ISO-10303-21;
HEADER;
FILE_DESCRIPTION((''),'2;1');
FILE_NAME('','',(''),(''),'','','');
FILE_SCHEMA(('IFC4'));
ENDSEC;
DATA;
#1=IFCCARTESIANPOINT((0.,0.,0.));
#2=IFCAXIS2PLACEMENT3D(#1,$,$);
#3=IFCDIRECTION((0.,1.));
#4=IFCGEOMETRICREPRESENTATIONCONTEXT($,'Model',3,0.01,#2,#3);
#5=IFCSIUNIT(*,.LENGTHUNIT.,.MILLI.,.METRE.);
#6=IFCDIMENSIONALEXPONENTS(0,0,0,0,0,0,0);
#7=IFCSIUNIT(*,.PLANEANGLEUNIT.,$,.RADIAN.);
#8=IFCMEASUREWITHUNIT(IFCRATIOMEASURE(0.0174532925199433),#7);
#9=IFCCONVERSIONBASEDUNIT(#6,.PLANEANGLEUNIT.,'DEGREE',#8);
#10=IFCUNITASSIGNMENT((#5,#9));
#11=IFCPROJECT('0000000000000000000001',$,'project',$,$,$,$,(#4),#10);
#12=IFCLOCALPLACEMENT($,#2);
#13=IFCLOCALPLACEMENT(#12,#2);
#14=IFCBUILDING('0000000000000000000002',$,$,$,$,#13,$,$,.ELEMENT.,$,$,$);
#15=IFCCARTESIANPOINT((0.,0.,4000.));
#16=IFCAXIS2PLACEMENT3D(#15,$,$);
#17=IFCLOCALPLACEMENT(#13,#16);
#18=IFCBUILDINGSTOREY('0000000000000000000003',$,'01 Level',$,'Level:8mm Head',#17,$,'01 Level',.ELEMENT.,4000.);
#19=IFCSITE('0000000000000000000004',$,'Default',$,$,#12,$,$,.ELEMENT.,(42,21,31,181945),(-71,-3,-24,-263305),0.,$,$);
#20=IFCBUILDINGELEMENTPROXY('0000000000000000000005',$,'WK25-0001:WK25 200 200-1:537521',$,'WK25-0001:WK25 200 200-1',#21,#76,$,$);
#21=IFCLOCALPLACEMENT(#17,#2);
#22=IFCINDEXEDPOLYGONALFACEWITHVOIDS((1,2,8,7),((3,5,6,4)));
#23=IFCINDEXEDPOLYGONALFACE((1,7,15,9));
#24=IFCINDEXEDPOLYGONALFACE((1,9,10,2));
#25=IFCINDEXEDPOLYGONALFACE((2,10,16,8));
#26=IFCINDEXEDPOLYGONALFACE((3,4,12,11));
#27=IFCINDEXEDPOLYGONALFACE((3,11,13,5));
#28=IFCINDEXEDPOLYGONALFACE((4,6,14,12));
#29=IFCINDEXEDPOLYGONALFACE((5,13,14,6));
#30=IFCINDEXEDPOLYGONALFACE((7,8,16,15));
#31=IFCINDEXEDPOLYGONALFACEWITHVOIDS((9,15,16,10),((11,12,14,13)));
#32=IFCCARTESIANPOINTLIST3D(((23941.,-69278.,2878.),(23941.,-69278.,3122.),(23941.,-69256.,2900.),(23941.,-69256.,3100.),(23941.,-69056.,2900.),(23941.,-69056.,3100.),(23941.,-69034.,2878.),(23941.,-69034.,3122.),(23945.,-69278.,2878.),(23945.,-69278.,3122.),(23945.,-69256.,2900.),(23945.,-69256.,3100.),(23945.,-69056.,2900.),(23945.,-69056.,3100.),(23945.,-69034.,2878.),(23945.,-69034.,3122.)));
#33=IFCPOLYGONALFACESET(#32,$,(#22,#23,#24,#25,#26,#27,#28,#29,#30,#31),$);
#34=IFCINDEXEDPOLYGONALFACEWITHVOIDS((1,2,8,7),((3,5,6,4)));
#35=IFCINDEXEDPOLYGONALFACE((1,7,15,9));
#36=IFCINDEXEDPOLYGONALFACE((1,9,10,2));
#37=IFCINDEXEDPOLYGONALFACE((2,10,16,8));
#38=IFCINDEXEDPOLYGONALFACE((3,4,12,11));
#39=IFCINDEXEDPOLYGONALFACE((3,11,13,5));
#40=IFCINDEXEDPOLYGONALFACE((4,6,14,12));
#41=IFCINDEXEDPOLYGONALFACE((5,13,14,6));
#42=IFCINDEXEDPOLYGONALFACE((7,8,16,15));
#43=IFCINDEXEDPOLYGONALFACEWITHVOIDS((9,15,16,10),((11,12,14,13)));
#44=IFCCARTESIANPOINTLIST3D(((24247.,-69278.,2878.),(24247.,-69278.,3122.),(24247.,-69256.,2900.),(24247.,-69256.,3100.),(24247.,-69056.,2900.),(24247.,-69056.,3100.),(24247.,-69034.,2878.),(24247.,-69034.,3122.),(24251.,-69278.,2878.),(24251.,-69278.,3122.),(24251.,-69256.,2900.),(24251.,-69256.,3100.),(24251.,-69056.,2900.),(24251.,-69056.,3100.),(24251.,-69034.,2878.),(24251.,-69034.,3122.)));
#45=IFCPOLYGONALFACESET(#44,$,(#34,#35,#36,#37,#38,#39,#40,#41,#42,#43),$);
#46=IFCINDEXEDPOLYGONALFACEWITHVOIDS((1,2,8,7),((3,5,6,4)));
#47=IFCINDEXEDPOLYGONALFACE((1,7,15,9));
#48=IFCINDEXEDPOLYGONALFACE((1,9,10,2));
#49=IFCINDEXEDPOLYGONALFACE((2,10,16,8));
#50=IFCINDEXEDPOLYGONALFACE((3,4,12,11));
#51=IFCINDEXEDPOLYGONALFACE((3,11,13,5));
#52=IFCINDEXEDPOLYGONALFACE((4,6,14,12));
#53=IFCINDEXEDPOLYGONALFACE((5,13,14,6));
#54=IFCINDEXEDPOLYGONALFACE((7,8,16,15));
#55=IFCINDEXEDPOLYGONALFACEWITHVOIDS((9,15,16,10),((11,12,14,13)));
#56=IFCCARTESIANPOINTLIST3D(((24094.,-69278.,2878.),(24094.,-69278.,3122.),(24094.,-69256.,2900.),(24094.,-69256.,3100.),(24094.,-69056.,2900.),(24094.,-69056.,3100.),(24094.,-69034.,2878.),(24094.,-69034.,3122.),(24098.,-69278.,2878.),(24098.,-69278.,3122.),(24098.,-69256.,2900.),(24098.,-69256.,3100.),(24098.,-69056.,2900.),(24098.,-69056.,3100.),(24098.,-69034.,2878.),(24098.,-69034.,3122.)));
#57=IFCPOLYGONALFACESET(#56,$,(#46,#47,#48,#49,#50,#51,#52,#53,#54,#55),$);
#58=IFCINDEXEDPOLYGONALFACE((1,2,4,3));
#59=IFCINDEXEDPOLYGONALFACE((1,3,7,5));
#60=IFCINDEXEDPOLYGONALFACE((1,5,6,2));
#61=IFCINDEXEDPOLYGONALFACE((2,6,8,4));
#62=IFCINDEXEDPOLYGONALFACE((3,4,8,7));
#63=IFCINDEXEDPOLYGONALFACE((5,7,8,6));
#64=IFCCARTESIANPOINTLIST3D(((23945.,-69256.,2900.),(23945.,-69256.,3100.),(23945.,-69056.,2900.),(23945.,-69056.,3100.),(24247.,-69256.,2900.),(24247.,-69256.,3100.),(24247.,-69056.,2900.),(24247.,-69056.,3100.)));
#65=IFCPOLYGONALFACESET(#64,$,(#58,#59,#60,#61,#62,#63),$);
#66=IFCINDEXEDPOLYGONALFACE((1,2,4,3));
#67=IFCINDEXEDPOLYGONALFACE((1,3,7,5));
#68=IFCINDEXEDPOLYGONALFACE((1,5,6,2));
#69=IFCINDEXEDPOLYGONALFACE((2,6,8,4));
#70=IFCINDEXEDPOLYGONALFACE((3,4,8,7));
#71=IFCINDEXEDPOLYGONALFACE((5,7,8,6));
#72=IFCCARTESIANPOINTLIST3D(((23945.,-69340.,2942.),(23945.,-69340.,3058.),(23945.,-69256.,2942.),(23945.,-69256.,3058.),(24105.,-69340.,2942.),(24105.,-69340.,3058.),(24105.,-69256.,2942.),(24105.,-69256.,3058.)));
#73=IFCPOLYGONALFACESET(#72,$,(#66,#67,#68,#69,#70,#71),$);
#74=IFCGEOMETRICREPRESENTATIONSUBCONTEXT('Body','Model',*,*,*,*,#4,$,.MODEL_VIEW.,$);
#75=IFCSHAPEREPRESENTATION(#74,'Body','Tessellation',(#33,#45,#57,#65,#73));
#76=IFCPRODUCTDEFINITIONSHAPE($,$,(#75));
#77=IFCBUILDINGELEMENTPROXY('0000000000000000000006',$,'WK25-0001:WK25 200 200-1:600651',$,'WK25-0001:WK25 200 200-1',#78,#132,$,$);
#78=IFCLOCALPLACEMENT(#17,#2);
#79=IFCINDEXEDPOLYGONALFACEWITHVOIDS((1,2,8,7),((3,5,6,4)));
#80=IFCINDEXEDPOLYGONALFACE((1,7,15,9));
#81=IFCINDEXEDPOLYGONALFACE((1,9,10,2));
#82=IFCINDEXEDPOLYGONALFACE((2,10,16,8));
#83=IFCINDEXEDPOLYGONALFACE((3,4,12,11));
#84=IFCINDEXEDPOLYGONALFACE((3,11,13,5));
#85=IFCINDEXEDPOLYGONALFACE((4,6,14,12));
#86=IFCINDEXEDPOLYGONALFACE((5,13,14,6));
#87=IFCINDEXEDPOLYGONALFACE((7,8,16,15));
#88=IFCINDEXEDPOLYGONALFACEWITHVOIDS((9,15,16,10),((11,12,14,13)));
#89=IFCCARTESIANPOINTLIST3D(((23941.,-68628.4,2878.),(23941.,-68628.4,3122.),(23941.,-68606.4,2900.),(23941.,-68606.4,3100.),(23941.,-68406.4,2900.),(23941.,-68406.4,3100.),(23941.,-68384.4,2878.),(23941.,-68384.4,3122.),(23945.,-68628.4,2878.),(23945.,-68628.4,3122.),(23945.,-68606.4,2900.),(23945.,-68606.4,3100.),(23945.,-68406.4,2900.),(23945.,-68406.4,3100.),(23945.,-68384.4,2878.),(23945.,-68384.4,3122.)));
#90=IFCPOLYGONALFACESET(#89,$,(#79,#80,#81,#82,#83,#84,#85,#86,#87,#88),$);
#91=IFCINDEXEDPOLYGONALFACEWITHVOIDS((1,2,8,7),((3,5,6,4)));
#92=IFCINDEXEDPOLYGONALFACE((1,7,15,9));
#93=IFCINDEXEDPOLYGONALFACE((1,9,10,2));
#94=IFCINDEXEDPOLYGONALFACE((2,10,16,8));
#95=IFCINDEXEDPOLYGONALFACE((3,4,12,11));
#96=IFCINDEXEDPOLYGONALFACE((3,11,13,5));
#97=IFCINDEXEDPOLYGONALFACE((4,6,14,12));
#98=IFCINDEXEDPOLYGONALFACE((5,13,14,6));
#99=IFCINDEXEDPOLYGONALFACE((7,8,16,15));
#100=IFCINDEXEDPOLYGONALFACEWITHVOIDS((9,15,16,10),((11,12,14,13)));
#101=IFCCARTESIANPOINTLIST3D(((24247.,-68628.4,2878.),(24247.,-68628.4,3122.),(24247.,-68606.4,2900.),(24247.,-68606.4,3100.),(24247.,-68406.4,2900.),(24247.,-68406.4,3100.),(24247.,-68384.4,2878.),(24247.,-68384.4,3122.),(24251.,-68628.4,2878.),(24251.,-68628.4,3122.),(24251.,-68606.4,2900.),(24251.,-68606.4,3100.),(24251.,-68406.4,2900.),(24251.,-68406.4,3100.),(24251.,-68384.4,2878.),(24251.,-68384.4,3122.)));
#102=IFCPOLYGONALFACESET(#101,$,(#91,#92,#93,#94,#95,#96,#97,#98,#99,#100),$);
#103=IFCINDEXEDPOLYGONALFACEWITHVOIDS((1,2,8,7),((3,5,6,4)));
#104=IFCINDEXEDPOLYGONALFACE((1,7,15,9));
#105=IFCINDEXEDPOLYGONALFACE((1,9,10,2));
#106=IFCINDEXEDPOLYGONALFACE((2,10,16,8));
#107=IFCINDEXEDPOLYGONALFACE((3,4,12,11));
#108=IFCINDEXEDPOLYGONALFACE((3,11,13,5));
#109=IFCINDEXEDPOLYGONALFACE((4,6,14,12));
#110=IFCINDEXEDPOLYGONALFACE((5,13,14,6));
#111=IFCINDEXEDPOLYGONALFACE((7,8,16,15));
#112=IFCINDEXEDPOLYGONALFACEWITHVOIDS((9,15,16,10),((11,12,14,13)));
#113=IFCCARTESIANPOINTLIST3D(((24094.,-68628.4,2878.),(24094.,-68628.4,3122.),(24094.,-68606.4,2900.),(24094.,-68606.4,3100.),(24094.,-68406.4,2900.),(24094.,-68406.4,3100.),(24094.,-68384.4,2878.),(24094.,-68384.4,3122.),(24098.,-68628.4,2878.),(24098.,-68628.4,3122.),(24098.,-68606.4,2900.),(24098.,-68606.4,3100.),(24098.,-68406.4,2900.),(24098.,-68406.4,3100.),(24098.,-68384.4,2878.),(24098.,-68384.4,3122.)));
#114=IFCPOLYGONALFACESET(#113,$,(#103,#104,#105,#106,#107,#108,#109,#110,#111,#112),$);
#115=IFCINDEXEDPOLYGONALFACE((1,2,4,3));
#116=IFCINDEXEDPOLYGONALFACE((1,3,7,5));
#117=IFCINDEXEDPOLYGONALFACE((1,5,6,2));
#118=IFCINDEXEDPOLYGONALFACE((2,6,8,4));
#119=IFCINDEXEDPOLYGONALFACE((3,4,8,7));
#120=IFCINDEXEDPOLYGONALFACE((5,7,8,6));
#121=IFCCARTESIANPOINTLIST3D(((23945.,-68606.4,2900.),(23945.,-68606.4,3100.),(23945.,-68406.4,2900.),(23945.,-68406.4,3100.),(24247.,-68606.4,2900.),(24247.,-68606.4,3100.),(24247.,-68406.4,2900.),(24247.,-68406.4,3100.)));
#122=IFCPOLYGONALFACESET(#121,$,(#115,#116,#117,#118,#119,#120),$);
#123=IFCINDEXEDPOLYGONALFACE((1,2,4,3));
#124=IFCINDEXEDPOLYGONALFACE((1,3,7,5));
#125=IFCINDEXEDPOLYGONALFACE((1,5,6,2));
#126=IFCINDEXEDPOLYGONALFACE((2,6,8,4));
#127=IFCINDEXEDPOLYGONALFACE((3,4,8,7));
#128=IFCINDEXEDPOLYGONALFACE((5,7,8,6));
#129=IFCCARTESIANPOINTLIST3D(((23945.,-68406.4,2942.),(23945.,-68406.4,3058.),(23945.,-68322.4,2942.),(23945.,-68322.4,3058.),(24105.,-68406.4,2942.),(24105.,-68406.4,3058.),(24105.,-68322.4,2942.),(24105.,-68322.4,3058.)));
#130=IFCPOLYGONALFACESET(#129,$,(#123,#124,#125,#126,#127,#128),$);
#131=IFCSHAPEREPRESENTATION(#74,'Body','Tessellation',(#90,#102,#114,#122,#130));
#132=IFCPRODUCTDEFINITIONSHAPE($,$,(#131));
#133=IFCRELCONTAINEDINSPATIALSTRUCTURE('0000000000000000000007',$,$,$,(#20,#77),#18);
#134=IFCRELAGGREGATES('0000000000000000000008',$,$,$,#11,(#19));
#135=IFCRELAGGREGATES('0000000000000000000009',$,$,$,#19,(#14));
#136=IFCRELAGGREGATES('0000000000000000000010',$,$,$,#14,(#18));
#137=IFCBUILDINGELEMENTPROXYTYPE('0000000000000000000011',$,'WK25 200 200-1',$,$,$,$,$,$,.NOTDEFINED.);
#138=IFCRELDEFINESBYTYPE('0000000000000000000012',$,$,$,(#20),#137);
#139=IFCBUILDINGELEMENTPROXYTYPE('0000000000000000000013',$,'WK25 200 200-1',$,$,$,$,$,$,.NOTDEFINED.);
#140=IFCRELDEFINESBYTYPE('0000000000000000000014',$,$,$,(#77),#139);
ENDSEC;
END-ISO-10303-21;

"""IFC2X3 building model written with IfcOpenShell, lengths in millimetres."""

from ifc_helpers import new_model, entity, si_unit, converted_unit, direction, frame, frame_2d, origin, origin_2d_with_axis, place, context, subcontext, project, spatial, polyline, rectangle, outline, extrude, source, transform, mapped, type_object, type_shapes, element, save


model = new_model("IFC2X3")

# Units and contexts
model_context = context("Model", 3, precision=0.01, world=origin(), true_north=direction((0.0, 1.0)))
body_context = subcontext(model_context, "Body", "Model", "MODEL_VIEW")
ifc_project = project(units=[si_unit("LENGTHUNIT", "METRE", prefix="MILLI"), converted_unit("PLANEANGLEUNIT", "DEGREE", entity("IfcRatioMeasure", 0.0174532925199433), si_unit("PLANEANGLEUNIT", "RADIAN"), dimensions=[0, 0, 0, 0, 0, 0, 0])], contexts=[model_context])

# Site, building, storey
site_placement = place(None, origin())
site = spatial("IfcSite", under=ifc_project, at=site_placement, Name="Default", CompositionType="ELEMENT", RefLatitude=(42, 21, 31, 181945), RefLongitude=(-71, -3, -24, -263305), RefElevation=0.0)
building_placement = place(site_placement, origin())
building = spatial("IfcBuilding", under=site, at=building_placement, CompositionType="ELEMENT")
storey_placement = place(building_placement, frame((0.0, 0.0, 4000.0)))
storey = spatial("IfcBuildingStorey", under=building, at=storey_placement, Name="01 Level", ObjectType="Level:8mm Head", LongName="01 Level", CompositionType="ELEMENT", Elevation=4000.0)

# Building element proxies
building_element_proxy_type_1 = type_object("IfcBuildingElementProxyType", Name="WK25 200 200-1", PredefinedType="NOTDEFINED")
shared_shape_1 = source(origin(), body_context, "Body", "SweptSolid", [
    extrude(outline(polyline([(-122.0, -122.0), (122.0, -122.0), (122.0, 122.0), (-122.0, 122.0), (-122.0, -122.0)]), holes=[polyline([(-100.0, -100.0), (-100.0, 100.0), (100.0, 100.0), (100.0, -100.0), (-100.0, -100.0)])]), frame((151.0, 0.0, 0.0), z_axis=(1.0, 0.0, 0.0), x_axis=(0.0, 0.0, -1.0)), (0.0, 0.0, 1.0), 4.0),
    extrude(outline(polyline([(-122.0, -122.0), (122.0, -122.0), (122.0, 122.0), (-122.0, 122.0), (-122.0, -122.0)]), holes=[polyline([(-100.0, -100.0), (-100.0, 100.0), (100.0, 100.0), (100.0, -100.0), (-100.0, -100.0)])]), frame((-155.0, 0.0, 0.0), z_axis=(1.0, 0.0, 0.0), x_axis=(0.0, -1.0, 0.0)), (0.0, 0.0, 1.0), 4.0),
    extrude(outline(polyline([(-122.0, -122.0), (122.0, -122.0), (122.0, 122.0), (-122.0, 122.0), (-122.0, -122.0)]), holes=[polyline([(-100.0, -100.0), (-100.0, 100.0), (100.0, 100.0), (100.0, -100.0), (-100.0, -100.0)])]), frame((-2.0, 0.0, 0.0), z_axis=(1.0, 0.0, 0.0), x_axis=(0.0, -1.0, 0.0)), (0.0, 0.0, 1.0), 4.0),
    extrude(rectangle(XDim=302.0, YDim=200.0, at=origin_2d_with_axis()), frame((0.0, 0.0, -100.0), z_axis=(0.0, 0.0, 1.0), x_axis=(-1.0, 0.0, 0.0)), (0.0, 0.0, 1.0), 200.0),
    extrude(rectangle(XDim=84.0, YDim=160.0, at=frame_2d((0.0, 0.0), x_axis=(1.0, 0.0))), frame((71.0, -142.0, -58.0), z_axis=(0.0, 0.0, 1.0), x_axis=(0.0, -1.0, 0.0)), (0.0, 0.0, 1.0), 116.0),
])
type_shapes(building_element_proxy_type_1, [shared_shape_1])
proxy_1_placement = place(storey_placement, frame((24096.0, -69156.0, 3000.0), z_axis=(0.0, 0.0, -1.0), x_axis=(-1.0, 0.0, 0.0)))
element("IfcBuildingElementProxy", 1, at=proxy_1_placement, inside=storey, type_object=building_element_proxy_type_1, Name="WK25-0001:WK25 200 200-1:537521", ObjectType="WK25-0001:WK25 200 200-1", context=body_context, shape_type="MappedRepresentation", body=[
    mapped(shared_shape_1, transform((0.0, 0.0, 0.0), scale=1.0)),
])
building_element_proxy_type_2 = type_object("IfcBuildingElementProxyType", Name="WK25 200 200-1", PredefinedType="NOTDEFINED")
shared_shape_2 = source(origin(), body_context, "Body", "SweptSolid", [
    extrude(outline(polyline([(-122.0, -122.0), (122.0, -122.0), (122.0, 122.0), (-122.0, 122.0), (-122.0, -122.0)]), holes=[polyline([(-100.0, -100.0), (-100.0, 100.0), (100.0, 100.0), (100.0, -100.0), (-100.0, -100.0)])]), frame((151.0, 0.0, 0.0), z_axis=(1.0, 0.0, 0.0), x_axis=(0.0, -1.0, 0.0)), (0.0, 0.0, 1.0), 4.0),
    extrude(outline(polyline([(-122.0, -122.0), (122.0, -122.0), (122.0, 122.0), (-122.0, 122.0), (-122.0, -122.0)]), holes=[polyline([(-100.0, -100.0), (-100.0, 100.0), (100.0, 100.0), (100.0, -100.0), (-100.0, -100.0)])]), frame((-155.0, 0.0, 0.0), z_axis=(1.0, 0.0, 0.0), x_axis=(0.0, 0.0, -1.0)), (0.0, 0.0, 1.0), 4.0),
    extrude(outline(polyline([(-122.0, -122.0), (122.0, -122.0), (122.0, 122.0), (-122.0, 122.0), (-122.0, -122.0)]), holes=[polyline([(-100.0, -100.0), (-100.0, 100.0), (100.0, 100.0), (100.0, -100.0), (-100.0, -100.0)])]), frame((-2.0, 0.0, 0.0), z_axis=(1.0, 0.0, 0.0), x_axis=(0.0, 0.0, -1.0)), (0.0, 0.0, 1.0), 4.0),
    extrude(rectangle(XDim=200.0, YDim=302.0, at=origin_2d_with_axis()), frame((0.0, 0.0, -100.0), z_axis=(0.0, 0.0, 1.0), x_axis=(0.0, 1.0, 0.0)), (0.0, 0.0, 1.0), 200.0),
    extrude(rectangle(XDim=160.0, YDim=84.0, at=frame_2d((0.0, 0.0), x_axis=(1.0, 0.0))), frame((71.0, 142.0, -58.0)), (0.0, 0.0, 1.0), 116.0),
])
type_shapes(building_element_proxy_type_2, [shared_shape_2])
proxy_2_placement = place(storey_placement, frame((24096.0, -68506.4, 3000.0), z_axis=(0.0, 0.0, -1.0), x_axis=(-1.0, 0.0, 0.0)))
element("IfcBuildingElementProxy", 2, at=proxy_2_placement, inside=storey, type_object=building_element_proxy_type_2, Name="WK25-0001:WK25 200 200-1:600651", ObjectType="WK25-0001:WK25 200 200-1", context=body_context, shape_type="MappedRepresentation", body=[
    mapped(shared_shape_2, transform((0.0, 0.0, 0.0), scale=1.0)),
])

save(model, "model.ifc")
